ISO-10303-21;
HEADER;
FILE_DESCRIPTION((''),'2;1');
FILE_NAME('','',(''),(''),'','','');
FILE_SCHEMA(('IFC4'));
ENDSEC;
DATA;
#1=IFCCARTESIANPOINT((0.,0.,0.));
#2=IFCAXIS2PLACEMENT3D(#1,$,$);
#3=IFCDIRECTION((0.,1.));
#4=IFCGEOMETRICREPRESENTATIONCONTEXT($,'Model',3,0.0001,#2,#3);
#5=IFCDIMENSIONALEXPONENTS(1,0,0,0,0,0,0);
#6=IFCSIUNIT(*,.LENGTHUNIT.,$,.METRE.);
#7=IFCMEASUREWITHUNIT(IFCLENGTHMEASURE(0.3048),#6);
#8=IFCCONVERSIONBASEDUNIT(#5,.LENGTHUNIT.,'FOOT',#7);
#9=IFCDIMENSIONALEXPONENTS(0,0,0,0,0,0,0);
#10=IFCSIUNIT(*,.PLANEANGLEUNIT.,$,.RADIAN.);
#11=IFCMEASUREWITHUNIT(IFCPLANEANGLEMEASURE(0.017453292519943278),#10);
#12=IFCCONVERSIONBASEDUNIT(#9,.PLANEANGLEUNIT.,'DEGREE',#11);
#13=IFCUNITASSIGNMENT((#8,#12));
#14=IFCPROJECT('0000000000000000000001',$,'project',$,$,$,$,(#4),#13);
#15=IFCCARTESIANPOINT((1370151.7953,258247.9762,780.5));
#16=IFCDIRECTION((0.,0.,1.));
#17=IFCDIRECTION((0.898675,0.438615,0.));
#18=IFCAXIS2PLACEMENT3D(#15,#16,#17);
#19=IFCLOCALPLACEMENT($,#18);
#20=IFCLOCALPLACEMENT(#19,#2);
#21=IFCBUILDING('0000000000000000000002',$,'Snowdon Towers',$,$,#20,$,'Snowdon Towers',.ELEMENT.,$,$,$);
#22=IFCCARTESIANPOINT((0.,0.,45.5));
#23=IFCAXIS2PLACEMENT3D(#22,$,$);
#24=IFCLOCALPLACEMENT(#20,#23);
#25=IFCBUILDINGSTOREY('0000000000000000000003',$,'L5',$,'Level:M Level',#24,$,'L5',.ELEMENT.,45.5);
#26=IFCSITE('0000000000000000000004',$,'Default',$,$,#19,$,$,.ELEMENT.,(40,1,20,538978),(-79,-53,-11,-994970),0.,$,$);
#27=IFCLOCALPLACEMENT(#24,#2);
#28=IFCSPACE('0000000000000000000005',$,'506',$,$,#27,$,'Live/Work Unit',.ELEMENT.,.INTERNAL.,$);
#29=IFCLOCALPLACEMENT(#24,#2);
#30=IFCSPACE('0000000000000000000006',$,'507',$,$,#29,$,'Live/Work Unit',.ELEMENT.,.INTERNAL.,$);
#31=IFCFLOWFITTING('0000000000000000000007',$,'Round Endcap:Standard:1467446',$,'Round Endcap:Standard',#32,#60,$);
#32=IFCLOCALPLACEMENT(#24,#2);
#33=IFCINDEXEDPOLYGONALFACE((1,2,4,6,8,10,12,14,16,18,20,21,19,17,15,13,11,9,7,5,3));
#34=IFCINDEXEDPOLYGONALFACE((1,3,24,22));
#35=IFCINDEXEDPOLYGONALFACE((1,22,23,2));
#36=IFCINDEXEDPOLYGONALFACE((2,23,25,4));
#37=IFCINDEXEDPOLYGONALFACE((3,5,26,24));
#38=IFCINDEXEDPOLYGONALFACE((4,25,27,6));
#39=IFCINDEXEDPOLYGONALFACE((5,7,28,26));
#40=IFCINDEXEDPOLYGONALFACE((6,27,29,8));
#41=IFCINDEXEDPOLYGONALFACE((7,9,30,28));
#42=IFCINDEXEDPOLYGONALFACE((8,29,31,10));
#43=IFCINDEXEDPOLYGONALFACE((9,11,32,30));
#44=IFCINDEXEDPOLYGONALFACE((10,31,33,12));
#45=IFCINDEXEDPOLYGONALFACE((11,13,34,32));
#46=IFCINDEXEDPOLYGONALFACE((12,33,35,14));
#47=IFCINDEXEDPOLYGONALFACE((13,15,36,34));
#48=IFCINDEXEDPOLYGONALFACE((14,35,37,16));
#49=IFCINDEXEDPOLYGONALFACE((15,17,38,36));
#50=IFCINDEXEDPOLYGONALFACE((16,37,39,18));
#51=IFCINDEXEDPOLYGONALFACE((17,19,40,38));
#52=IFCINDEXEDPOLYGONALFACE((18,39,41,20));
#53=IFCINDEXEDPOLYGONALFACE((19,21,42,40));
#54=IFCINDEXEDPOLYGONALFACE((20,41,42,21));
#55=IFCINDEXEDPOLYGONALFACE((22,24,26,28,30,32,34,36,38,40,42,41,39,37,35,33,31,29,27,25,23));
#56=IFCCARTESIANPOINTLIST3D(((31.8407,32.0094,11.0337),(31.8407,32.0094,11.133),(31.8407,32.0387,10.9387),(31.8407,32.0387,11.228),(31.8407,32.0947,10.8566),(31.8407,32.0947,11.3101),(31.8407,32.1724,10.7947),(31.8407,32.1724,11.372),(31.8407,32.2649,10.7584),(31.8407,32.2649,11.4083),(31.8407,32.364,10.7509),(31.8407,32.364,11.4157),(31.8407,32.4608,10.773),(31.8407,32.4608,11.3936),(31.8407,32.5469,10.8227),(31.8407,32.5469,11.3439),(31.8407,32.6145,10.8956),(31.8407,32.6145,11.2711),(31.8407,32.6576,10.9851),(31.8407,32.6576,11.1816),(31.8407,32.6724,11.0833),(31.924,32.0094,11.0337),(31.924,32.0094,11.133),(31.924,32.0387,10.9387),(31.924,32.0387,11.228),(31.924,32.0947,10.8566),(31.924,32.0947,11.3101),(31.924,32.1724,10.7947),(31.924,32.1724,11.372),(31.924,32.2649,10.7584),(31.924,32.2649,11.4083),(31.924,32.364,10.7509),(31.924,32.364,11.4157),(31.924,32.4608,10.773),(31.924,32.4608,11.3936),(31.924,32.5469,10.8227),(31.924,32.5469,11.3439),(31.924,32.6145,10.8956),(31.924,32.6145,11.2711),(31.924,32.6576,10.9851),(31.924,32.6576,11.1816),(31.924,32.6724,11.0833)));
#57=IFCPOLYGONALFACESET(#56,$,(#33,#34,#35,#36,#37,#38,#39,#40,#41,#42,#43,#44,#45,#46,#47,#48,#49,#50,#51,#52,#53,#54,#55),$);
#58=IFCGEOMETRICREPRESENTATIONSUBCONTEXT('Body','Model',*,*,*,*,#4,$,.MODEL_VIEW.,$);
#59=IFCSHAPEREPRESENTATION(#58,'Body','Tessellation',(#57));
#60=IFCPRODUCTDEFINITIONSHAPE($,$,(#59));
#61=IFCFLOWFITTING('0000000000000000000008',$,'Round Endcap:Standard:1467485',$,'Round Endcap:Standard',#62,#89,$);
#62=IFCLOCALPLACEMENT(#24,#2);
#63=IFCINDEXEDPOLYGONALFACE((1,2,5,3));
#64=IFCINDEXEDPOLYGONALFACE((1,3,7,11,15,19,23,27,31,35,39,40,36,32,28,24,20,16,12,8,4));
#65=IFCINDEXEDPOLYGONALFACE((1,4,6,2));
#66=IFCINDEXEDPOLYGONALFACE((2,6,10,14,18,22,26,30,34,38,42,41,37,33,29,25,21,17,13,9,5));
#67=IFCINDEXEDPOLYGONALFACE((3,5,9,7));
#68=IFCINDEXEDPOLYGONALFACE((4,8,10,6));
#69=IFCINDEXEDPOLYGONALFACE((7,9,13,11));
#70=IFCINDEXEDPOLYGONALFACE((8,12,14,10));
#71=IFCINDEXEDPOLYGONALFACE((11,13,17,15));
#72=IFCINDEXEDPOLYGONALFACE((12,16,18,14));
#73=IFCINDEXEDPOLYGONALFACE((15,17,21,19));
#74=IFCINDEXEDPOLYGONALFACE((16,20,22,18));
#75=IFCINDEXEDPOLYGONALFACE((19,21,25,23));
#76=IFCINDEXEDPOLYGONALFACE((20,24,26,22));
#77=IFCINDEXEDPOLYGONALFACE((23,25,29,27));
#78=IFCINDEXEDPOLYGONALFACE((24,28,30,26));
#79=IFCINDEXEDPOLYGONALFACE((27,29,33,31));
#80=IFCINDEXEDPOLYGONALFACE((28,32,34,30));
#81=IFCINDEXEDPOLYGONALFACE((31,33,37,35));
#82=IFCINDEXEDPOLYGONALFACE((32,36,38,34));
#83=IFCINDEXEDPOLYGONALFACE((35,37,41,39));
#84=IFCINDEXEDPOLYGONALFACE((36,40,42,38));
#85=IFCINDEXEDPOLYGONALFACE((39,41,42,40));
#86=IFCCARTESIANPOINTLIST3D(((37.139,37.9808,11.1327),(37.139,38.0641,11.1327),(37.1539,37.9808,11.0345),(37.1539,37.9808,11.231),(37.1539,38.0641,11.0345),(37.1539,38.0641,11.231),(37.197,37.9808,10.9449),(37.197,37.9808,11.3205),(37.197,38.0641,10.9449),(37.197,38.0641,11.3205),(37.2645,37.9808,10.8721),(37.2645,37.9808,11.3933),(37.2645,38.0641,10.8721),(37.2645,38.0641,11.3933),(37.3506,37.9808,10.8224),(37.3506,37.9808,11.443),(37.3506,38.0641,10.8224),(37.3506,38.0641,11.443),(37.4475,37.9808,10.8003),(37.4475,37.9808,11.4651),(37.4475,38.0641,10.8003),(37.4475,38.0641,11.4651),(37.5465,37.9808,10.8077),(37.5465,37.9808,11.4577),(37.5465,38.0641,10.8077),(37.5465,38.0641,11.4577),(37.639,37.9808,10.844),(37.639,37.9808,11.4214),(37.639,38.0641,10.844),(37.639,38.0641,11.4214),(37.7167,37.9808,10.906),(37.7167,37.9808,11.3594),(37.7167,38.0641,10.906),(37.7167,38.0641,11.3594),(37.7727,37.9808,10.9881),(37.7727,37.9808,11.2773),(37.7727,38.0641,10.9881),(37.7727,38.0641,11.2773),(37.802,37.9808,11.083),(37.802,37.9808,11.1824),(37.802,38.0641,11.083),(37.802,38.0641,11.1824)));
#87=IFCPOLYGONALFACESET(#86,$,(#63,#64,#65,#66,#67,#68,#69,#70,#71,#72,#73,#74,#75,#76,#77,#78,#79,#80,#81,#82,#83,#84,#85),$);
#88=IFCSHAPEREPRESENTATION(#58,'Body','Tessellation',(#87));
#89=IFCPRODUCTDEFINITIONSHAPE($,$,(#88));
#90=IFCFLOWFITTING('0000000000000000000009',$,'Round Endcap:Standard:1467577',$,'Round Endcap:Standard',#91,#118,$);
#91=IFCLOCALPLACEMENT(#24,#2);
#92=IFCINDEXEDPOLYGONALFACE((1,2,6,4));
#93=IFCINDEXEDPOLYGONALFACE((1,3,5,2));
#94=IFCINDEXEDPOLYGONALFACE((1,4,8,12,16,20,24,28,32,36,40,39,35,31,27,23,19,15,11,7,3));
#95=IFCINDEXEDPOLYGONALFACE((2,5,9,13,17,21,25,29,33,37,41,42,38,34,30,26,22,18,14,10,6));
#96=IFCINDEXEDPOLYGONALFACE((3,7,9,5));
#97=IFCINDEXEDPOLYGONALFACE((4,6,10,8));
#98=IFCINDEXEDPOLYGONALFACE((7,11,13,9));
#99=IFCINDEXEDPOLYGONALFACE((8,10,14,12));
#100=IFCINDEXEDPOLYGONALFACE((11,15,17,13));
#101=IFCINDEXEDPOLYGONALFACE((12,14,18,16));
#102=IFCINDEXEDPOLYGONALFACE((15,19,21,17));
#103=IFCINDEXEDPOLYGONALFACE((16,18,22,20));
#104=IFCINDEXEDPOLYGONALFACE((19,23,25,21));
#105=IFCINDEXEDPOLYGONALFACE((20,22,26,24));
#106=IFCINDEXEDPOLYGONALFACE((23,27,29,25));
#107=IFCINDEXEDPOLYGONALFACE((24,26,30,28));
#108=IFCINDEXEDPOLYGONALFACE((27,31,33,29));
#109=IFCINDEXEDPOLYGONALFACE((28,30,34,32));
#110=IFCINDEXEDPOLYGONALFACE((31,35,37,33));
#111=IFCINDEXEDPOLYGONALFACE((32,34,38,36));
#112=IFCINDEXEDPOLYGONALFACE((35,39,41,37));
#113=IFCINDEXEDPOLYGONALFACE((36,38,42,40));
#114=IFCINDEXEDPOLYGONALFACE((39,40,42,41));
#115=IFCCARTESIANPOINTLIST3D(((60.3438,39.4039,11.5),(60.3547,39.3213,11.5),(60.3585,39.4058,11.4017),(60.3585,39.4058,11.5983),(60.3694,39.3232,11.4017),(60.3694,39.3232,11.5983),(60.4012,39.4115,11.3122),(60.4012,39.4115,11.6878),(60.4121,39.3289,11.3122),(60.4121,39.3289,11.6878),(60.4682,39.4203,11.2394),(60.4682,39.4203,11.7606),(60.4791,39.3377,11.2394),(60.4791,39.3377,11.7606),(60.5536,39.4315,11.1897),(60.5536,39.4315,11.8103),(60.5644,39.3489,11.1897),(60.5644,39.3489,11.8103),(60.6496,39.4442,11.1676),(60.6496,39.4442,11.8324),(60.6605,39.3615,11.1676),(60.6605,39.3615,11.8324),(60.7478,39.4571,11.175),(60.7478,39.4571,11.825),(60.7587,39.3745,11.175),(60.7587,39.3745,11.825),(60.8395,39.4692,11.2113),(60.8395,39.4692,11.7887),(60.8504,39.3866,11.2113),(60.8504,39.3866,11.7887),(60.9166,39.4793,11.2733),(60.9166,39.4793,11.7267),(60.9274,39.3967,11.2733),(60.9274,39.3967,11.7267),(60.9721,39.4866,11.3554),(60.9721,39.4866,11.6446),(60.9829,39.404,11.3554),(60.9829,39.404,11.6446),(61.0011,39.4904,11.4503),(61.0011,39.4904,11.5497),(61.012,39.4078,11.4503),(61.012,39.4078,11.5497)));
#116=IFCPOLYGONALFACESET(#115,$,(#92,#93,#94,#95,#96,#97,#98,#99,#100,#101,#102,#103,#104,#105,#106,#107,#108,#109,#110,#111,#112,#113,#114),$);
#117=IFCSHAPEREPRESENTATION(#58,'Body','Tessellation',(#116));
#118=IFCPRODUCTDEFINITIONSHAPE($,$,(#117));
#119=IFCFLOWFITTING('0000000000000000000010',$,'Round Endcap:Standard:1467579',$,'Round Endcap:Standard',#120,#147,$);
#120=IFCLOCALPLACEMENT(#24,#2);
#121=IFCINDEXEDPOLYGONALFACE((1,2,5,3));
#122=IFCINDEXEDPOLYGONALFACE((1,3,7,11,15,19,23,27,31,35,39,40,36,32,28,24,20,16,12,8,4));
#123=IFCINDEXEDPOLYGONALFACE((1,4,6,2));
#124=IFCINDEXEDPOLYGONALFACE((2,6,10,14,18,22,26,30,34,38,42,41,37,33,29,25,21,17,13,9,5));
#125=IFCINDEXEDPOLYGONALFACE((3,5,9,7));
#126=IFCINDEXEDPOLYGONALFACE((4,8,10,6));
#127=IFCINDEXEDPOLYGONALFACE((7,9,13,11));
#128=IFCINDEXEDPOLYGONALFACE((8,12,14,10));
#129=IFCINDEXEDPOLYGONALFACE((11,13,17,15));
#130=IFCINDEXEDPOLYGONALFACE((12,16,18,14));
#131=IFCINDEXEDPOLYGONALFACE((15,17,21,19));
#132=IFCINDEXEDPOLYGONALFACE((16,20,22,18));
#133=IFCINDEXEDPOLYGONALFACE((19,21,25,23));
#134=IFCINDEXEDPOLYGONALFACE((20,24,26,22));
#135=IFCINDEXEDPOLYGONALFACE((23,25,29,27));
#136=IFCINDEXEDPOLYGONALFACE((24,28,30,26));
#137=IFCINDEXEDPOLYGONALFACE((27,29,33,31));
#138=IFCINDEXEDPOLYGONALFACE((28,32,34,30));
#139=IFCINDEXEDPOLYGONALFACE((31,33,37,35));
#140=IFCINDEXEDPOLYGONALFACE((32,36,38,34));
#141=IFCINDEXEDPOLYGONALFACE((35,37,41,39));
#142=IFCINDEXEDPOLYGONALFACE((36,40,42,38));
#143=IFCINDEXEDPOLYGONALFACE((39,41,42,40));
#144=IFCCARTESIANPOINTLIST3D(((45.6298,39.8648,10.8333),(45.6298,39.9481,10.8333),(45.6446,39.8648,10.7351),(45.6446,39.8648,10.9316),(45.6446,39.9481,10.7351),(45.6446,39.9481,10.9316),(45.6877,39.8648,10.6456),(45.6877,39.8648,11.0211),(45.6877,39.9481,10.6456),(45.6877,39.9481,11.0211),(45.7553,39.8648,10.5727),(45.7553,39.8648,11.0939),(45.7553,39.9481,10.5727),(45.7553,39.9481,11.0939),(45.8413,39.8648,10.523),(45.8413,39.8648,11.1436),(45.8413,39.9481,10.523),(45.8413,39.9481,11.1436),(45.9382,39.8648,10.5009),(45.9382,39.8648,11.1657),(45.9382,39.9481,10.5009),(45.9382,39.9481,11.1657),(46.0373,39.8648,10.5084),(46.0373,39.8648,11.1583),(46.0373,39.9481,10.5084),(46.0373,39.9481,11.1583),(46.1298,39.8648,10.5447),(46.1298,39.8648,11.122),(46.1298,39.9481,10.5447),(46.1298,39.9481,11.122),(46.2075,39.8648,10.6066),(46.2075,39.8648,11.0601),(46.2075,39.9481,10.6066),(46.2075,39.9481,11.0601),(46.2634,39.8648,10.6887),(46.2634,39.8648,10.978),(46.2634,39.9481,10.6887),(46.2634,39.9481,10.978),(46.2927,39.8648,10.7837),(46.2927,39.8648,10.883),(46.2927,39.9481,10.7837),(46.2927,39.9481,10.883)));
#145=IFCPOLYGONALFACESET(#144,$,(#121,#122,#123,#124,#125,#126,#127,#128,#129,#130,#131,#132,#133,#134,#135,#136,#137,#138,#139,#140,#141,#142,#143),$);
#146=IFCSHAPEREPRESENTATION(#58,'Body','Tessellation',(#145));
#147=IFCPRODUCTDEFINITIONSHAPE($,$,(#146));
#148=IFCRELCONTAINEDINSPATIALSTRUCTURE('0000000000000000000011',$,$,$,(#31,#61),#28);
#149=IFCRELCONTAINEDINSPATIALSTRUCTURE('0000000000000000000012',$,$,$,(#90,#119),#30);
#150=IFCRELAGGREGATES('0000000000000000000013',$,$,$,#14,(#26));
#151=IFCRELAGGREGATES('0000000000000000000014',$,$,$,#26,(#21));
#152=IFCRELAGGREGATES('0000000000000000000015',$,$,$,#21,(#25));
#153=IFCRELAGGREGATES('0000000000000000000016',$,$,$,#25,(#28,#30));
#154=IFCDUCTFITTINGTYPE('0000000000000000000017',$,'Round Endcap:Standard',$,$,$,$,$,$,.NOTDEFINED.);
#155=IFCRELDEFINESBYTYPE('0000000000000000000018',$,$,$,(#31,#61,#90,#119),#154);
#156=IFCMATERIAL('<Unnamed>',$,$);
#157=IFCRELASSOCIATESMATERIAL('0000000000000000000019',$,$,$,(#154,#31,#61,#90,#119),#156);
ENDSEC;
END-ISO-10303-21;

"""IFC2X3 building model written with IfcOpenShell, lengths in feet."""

from ifc_helpers import new_model, entity, si_unit, converted_unit, direction, frame, frame_2d, origin, place, context, subcontext, project, spatial, circle, extrude, source, transform, mapped, material, type_object, type_shapes, element, save


model = new_model("IFC2X3")

# Units and contexts
model_context = context("Model", 3, precision=0.0001, world=origin(), true_north=direction((0.0, 1.0)))
body_context = subcontext(model_context, "Body", "Model", "MODEL_VIEW")
ifc_project = project(units=[converted_unit("LENGTHUNIT", "FOOT", entity("IfcLengthMeasure", 0.3048), si_unit("LENGTHUNIT", "METRE"), dimensions=[1, 0, 0, 0, 0, 0, 0]), converted_unit("PLANEANGLEUNIT", "DEGREE", entity("IfcPlaneAngleMeasure", 0.017453292519943278), si_unit("PLANEANGLEUNIT", "RADIAN"), dimensions=[0, 0, 0, 0, 0, 0, 0])], contexts=[model_context])

# Site, building, storey
site_placement = place(None, frame((1370151.7953, 258247.9762, 780.5), z_axis=(0.0, 0.0, 1.0), x_axis=(0.898675, 0.438615, 0.0)))
site = spatial("IfcSite", under=ifc_project, at=site_placement, Name="Default", CompositionType="ELEMENT", RefLatitude=(40, 1, 20, 538978), RefLongitude=(-79, -53, -11, -994970), RefElevation=0.0)
building_placement = place(site_placement, origin())
building = spatial("IfcBuilding", under=site, at=building_placement, Name="Snowdon Towers", LongName="Snowdon Towers", CompositionType="ELEMENT")
storey_placement = place(building_placement, frame((0.0, 0.0, 45.5)))
storey = spatial("IfcBuildingStorey", under=building, at=storey_placement, Name="L5", ObjectType="Level:M Level", LongName="L5", CompositionType="ELEMENT", Elevation=45.5)

# Shared definitions
space_1_placement = place(storey_placement, origin())
space_1 = spatial("IfcSpace", under=storey, at=space_1_placement, Name="506", LongName="Live/Work Unit", CompositionType="ELEMENT", InteriorOrExteriorSpace="INTERNAL")

# Flow fittings
ifc_material = material(Name="<Unnamed>")
duct_fitting_type = type_object("IfcDuctFittingType", Name="Round Endcap:Standard", PredefinedType="NOTDEFINED", material=ifc_material)
shared_shape_1 = source(origin(), body_context, "Body", "SweptSolid", [
    extrude(circle(Radius=0.3333, at=frame_2d((0.0, 0.0), x_axis=(1.0, 0.0))), frame((0.0, 0.0, 0.0), z_axis=(1.0, 0.0, 0.0), x_axis=(0.0, 1.0, 0.0)), (0.0, 0.0, 1.0), 0.0833),
])
type_shapes(duct_fitting_type, [shared_shape_1])
flow_fitting_1_placement = place(space_1_placement, frame((31.8407, 32.339, 11.0833)))
element("IfcFlowFitting", 1, at=flow_fitting_1_placement, inside=space_1, type_object=duct_fitting_type, material=ifc_material, Name="Round Endcap:Standard:1467446", ObjectType="Round Endcap:Standard", context=body_context, shape_type="MappedRepresentation", body=[
    mapped(shared_shape_1, transform((0.0, 0.0, 0.0), scale=1.0)),
])
flow_fitting_2_placement = place(space_1_placement, frame((37.4724, 37.9808, 11.1327), z_axis=(0.0, 0.0, 1.0), x_axis=(0.0, 1.0, 0.0)))
element("IfcFlowFitting", 2, at=flow_fitting_2_placement, inside=space_1, type_object=duct_fitting_type, material=ifc_material, Name="Round Endcap:Standard:1467485", ObjectType="Round Endcap:Standard", context=body_context, shape_type="MappedRepresentation", body=[
    mapped(shared_shape_1, transform((0.0, 0.0, 0.0), scale=1.0)),
])

# Shared definitions
space_2_placement = place(storey_placement, origin())
space_2 = spatial("IfcSpace", under=storey, at=space_2_placement, Name="507", LongName="Live/Work Unit", CompositionType="ELEMENT", InteriorOrExteriorSpace="INTERNAL")

# Flow fittings
for number, where, z_axis, x_axis, name in (
    (3, (60.6852, 39.3648, 11.5), (0.0, 0.0, 1.0), (-0.130526, 0.991445, 0.0), "Round Endcap:Standard:1467577"),
    (4, (45.9631, 39.8648, 10.8333), (0.0, 0.0, 1.0), (0.0, 1.0, 0.0), "Round Endcap:Standard:1467579"),
):
    element("IfcFlowFitting", number, at=place(space_2_placement, frame(where, z_axis=z_axis, x_axis=x_axis)), inside=space_2, type_object=duct_fitting_type, material=ifc_material, Name=name, ObjectType="Round Endcap:Standard", context=body_context, shape_type="MappedRepresentation", body=[
        mapped(shared_shape_1, transform((0.0, 0.0, 0.0), scale=1.0)),
    ])

save(model, "model.ifc")
